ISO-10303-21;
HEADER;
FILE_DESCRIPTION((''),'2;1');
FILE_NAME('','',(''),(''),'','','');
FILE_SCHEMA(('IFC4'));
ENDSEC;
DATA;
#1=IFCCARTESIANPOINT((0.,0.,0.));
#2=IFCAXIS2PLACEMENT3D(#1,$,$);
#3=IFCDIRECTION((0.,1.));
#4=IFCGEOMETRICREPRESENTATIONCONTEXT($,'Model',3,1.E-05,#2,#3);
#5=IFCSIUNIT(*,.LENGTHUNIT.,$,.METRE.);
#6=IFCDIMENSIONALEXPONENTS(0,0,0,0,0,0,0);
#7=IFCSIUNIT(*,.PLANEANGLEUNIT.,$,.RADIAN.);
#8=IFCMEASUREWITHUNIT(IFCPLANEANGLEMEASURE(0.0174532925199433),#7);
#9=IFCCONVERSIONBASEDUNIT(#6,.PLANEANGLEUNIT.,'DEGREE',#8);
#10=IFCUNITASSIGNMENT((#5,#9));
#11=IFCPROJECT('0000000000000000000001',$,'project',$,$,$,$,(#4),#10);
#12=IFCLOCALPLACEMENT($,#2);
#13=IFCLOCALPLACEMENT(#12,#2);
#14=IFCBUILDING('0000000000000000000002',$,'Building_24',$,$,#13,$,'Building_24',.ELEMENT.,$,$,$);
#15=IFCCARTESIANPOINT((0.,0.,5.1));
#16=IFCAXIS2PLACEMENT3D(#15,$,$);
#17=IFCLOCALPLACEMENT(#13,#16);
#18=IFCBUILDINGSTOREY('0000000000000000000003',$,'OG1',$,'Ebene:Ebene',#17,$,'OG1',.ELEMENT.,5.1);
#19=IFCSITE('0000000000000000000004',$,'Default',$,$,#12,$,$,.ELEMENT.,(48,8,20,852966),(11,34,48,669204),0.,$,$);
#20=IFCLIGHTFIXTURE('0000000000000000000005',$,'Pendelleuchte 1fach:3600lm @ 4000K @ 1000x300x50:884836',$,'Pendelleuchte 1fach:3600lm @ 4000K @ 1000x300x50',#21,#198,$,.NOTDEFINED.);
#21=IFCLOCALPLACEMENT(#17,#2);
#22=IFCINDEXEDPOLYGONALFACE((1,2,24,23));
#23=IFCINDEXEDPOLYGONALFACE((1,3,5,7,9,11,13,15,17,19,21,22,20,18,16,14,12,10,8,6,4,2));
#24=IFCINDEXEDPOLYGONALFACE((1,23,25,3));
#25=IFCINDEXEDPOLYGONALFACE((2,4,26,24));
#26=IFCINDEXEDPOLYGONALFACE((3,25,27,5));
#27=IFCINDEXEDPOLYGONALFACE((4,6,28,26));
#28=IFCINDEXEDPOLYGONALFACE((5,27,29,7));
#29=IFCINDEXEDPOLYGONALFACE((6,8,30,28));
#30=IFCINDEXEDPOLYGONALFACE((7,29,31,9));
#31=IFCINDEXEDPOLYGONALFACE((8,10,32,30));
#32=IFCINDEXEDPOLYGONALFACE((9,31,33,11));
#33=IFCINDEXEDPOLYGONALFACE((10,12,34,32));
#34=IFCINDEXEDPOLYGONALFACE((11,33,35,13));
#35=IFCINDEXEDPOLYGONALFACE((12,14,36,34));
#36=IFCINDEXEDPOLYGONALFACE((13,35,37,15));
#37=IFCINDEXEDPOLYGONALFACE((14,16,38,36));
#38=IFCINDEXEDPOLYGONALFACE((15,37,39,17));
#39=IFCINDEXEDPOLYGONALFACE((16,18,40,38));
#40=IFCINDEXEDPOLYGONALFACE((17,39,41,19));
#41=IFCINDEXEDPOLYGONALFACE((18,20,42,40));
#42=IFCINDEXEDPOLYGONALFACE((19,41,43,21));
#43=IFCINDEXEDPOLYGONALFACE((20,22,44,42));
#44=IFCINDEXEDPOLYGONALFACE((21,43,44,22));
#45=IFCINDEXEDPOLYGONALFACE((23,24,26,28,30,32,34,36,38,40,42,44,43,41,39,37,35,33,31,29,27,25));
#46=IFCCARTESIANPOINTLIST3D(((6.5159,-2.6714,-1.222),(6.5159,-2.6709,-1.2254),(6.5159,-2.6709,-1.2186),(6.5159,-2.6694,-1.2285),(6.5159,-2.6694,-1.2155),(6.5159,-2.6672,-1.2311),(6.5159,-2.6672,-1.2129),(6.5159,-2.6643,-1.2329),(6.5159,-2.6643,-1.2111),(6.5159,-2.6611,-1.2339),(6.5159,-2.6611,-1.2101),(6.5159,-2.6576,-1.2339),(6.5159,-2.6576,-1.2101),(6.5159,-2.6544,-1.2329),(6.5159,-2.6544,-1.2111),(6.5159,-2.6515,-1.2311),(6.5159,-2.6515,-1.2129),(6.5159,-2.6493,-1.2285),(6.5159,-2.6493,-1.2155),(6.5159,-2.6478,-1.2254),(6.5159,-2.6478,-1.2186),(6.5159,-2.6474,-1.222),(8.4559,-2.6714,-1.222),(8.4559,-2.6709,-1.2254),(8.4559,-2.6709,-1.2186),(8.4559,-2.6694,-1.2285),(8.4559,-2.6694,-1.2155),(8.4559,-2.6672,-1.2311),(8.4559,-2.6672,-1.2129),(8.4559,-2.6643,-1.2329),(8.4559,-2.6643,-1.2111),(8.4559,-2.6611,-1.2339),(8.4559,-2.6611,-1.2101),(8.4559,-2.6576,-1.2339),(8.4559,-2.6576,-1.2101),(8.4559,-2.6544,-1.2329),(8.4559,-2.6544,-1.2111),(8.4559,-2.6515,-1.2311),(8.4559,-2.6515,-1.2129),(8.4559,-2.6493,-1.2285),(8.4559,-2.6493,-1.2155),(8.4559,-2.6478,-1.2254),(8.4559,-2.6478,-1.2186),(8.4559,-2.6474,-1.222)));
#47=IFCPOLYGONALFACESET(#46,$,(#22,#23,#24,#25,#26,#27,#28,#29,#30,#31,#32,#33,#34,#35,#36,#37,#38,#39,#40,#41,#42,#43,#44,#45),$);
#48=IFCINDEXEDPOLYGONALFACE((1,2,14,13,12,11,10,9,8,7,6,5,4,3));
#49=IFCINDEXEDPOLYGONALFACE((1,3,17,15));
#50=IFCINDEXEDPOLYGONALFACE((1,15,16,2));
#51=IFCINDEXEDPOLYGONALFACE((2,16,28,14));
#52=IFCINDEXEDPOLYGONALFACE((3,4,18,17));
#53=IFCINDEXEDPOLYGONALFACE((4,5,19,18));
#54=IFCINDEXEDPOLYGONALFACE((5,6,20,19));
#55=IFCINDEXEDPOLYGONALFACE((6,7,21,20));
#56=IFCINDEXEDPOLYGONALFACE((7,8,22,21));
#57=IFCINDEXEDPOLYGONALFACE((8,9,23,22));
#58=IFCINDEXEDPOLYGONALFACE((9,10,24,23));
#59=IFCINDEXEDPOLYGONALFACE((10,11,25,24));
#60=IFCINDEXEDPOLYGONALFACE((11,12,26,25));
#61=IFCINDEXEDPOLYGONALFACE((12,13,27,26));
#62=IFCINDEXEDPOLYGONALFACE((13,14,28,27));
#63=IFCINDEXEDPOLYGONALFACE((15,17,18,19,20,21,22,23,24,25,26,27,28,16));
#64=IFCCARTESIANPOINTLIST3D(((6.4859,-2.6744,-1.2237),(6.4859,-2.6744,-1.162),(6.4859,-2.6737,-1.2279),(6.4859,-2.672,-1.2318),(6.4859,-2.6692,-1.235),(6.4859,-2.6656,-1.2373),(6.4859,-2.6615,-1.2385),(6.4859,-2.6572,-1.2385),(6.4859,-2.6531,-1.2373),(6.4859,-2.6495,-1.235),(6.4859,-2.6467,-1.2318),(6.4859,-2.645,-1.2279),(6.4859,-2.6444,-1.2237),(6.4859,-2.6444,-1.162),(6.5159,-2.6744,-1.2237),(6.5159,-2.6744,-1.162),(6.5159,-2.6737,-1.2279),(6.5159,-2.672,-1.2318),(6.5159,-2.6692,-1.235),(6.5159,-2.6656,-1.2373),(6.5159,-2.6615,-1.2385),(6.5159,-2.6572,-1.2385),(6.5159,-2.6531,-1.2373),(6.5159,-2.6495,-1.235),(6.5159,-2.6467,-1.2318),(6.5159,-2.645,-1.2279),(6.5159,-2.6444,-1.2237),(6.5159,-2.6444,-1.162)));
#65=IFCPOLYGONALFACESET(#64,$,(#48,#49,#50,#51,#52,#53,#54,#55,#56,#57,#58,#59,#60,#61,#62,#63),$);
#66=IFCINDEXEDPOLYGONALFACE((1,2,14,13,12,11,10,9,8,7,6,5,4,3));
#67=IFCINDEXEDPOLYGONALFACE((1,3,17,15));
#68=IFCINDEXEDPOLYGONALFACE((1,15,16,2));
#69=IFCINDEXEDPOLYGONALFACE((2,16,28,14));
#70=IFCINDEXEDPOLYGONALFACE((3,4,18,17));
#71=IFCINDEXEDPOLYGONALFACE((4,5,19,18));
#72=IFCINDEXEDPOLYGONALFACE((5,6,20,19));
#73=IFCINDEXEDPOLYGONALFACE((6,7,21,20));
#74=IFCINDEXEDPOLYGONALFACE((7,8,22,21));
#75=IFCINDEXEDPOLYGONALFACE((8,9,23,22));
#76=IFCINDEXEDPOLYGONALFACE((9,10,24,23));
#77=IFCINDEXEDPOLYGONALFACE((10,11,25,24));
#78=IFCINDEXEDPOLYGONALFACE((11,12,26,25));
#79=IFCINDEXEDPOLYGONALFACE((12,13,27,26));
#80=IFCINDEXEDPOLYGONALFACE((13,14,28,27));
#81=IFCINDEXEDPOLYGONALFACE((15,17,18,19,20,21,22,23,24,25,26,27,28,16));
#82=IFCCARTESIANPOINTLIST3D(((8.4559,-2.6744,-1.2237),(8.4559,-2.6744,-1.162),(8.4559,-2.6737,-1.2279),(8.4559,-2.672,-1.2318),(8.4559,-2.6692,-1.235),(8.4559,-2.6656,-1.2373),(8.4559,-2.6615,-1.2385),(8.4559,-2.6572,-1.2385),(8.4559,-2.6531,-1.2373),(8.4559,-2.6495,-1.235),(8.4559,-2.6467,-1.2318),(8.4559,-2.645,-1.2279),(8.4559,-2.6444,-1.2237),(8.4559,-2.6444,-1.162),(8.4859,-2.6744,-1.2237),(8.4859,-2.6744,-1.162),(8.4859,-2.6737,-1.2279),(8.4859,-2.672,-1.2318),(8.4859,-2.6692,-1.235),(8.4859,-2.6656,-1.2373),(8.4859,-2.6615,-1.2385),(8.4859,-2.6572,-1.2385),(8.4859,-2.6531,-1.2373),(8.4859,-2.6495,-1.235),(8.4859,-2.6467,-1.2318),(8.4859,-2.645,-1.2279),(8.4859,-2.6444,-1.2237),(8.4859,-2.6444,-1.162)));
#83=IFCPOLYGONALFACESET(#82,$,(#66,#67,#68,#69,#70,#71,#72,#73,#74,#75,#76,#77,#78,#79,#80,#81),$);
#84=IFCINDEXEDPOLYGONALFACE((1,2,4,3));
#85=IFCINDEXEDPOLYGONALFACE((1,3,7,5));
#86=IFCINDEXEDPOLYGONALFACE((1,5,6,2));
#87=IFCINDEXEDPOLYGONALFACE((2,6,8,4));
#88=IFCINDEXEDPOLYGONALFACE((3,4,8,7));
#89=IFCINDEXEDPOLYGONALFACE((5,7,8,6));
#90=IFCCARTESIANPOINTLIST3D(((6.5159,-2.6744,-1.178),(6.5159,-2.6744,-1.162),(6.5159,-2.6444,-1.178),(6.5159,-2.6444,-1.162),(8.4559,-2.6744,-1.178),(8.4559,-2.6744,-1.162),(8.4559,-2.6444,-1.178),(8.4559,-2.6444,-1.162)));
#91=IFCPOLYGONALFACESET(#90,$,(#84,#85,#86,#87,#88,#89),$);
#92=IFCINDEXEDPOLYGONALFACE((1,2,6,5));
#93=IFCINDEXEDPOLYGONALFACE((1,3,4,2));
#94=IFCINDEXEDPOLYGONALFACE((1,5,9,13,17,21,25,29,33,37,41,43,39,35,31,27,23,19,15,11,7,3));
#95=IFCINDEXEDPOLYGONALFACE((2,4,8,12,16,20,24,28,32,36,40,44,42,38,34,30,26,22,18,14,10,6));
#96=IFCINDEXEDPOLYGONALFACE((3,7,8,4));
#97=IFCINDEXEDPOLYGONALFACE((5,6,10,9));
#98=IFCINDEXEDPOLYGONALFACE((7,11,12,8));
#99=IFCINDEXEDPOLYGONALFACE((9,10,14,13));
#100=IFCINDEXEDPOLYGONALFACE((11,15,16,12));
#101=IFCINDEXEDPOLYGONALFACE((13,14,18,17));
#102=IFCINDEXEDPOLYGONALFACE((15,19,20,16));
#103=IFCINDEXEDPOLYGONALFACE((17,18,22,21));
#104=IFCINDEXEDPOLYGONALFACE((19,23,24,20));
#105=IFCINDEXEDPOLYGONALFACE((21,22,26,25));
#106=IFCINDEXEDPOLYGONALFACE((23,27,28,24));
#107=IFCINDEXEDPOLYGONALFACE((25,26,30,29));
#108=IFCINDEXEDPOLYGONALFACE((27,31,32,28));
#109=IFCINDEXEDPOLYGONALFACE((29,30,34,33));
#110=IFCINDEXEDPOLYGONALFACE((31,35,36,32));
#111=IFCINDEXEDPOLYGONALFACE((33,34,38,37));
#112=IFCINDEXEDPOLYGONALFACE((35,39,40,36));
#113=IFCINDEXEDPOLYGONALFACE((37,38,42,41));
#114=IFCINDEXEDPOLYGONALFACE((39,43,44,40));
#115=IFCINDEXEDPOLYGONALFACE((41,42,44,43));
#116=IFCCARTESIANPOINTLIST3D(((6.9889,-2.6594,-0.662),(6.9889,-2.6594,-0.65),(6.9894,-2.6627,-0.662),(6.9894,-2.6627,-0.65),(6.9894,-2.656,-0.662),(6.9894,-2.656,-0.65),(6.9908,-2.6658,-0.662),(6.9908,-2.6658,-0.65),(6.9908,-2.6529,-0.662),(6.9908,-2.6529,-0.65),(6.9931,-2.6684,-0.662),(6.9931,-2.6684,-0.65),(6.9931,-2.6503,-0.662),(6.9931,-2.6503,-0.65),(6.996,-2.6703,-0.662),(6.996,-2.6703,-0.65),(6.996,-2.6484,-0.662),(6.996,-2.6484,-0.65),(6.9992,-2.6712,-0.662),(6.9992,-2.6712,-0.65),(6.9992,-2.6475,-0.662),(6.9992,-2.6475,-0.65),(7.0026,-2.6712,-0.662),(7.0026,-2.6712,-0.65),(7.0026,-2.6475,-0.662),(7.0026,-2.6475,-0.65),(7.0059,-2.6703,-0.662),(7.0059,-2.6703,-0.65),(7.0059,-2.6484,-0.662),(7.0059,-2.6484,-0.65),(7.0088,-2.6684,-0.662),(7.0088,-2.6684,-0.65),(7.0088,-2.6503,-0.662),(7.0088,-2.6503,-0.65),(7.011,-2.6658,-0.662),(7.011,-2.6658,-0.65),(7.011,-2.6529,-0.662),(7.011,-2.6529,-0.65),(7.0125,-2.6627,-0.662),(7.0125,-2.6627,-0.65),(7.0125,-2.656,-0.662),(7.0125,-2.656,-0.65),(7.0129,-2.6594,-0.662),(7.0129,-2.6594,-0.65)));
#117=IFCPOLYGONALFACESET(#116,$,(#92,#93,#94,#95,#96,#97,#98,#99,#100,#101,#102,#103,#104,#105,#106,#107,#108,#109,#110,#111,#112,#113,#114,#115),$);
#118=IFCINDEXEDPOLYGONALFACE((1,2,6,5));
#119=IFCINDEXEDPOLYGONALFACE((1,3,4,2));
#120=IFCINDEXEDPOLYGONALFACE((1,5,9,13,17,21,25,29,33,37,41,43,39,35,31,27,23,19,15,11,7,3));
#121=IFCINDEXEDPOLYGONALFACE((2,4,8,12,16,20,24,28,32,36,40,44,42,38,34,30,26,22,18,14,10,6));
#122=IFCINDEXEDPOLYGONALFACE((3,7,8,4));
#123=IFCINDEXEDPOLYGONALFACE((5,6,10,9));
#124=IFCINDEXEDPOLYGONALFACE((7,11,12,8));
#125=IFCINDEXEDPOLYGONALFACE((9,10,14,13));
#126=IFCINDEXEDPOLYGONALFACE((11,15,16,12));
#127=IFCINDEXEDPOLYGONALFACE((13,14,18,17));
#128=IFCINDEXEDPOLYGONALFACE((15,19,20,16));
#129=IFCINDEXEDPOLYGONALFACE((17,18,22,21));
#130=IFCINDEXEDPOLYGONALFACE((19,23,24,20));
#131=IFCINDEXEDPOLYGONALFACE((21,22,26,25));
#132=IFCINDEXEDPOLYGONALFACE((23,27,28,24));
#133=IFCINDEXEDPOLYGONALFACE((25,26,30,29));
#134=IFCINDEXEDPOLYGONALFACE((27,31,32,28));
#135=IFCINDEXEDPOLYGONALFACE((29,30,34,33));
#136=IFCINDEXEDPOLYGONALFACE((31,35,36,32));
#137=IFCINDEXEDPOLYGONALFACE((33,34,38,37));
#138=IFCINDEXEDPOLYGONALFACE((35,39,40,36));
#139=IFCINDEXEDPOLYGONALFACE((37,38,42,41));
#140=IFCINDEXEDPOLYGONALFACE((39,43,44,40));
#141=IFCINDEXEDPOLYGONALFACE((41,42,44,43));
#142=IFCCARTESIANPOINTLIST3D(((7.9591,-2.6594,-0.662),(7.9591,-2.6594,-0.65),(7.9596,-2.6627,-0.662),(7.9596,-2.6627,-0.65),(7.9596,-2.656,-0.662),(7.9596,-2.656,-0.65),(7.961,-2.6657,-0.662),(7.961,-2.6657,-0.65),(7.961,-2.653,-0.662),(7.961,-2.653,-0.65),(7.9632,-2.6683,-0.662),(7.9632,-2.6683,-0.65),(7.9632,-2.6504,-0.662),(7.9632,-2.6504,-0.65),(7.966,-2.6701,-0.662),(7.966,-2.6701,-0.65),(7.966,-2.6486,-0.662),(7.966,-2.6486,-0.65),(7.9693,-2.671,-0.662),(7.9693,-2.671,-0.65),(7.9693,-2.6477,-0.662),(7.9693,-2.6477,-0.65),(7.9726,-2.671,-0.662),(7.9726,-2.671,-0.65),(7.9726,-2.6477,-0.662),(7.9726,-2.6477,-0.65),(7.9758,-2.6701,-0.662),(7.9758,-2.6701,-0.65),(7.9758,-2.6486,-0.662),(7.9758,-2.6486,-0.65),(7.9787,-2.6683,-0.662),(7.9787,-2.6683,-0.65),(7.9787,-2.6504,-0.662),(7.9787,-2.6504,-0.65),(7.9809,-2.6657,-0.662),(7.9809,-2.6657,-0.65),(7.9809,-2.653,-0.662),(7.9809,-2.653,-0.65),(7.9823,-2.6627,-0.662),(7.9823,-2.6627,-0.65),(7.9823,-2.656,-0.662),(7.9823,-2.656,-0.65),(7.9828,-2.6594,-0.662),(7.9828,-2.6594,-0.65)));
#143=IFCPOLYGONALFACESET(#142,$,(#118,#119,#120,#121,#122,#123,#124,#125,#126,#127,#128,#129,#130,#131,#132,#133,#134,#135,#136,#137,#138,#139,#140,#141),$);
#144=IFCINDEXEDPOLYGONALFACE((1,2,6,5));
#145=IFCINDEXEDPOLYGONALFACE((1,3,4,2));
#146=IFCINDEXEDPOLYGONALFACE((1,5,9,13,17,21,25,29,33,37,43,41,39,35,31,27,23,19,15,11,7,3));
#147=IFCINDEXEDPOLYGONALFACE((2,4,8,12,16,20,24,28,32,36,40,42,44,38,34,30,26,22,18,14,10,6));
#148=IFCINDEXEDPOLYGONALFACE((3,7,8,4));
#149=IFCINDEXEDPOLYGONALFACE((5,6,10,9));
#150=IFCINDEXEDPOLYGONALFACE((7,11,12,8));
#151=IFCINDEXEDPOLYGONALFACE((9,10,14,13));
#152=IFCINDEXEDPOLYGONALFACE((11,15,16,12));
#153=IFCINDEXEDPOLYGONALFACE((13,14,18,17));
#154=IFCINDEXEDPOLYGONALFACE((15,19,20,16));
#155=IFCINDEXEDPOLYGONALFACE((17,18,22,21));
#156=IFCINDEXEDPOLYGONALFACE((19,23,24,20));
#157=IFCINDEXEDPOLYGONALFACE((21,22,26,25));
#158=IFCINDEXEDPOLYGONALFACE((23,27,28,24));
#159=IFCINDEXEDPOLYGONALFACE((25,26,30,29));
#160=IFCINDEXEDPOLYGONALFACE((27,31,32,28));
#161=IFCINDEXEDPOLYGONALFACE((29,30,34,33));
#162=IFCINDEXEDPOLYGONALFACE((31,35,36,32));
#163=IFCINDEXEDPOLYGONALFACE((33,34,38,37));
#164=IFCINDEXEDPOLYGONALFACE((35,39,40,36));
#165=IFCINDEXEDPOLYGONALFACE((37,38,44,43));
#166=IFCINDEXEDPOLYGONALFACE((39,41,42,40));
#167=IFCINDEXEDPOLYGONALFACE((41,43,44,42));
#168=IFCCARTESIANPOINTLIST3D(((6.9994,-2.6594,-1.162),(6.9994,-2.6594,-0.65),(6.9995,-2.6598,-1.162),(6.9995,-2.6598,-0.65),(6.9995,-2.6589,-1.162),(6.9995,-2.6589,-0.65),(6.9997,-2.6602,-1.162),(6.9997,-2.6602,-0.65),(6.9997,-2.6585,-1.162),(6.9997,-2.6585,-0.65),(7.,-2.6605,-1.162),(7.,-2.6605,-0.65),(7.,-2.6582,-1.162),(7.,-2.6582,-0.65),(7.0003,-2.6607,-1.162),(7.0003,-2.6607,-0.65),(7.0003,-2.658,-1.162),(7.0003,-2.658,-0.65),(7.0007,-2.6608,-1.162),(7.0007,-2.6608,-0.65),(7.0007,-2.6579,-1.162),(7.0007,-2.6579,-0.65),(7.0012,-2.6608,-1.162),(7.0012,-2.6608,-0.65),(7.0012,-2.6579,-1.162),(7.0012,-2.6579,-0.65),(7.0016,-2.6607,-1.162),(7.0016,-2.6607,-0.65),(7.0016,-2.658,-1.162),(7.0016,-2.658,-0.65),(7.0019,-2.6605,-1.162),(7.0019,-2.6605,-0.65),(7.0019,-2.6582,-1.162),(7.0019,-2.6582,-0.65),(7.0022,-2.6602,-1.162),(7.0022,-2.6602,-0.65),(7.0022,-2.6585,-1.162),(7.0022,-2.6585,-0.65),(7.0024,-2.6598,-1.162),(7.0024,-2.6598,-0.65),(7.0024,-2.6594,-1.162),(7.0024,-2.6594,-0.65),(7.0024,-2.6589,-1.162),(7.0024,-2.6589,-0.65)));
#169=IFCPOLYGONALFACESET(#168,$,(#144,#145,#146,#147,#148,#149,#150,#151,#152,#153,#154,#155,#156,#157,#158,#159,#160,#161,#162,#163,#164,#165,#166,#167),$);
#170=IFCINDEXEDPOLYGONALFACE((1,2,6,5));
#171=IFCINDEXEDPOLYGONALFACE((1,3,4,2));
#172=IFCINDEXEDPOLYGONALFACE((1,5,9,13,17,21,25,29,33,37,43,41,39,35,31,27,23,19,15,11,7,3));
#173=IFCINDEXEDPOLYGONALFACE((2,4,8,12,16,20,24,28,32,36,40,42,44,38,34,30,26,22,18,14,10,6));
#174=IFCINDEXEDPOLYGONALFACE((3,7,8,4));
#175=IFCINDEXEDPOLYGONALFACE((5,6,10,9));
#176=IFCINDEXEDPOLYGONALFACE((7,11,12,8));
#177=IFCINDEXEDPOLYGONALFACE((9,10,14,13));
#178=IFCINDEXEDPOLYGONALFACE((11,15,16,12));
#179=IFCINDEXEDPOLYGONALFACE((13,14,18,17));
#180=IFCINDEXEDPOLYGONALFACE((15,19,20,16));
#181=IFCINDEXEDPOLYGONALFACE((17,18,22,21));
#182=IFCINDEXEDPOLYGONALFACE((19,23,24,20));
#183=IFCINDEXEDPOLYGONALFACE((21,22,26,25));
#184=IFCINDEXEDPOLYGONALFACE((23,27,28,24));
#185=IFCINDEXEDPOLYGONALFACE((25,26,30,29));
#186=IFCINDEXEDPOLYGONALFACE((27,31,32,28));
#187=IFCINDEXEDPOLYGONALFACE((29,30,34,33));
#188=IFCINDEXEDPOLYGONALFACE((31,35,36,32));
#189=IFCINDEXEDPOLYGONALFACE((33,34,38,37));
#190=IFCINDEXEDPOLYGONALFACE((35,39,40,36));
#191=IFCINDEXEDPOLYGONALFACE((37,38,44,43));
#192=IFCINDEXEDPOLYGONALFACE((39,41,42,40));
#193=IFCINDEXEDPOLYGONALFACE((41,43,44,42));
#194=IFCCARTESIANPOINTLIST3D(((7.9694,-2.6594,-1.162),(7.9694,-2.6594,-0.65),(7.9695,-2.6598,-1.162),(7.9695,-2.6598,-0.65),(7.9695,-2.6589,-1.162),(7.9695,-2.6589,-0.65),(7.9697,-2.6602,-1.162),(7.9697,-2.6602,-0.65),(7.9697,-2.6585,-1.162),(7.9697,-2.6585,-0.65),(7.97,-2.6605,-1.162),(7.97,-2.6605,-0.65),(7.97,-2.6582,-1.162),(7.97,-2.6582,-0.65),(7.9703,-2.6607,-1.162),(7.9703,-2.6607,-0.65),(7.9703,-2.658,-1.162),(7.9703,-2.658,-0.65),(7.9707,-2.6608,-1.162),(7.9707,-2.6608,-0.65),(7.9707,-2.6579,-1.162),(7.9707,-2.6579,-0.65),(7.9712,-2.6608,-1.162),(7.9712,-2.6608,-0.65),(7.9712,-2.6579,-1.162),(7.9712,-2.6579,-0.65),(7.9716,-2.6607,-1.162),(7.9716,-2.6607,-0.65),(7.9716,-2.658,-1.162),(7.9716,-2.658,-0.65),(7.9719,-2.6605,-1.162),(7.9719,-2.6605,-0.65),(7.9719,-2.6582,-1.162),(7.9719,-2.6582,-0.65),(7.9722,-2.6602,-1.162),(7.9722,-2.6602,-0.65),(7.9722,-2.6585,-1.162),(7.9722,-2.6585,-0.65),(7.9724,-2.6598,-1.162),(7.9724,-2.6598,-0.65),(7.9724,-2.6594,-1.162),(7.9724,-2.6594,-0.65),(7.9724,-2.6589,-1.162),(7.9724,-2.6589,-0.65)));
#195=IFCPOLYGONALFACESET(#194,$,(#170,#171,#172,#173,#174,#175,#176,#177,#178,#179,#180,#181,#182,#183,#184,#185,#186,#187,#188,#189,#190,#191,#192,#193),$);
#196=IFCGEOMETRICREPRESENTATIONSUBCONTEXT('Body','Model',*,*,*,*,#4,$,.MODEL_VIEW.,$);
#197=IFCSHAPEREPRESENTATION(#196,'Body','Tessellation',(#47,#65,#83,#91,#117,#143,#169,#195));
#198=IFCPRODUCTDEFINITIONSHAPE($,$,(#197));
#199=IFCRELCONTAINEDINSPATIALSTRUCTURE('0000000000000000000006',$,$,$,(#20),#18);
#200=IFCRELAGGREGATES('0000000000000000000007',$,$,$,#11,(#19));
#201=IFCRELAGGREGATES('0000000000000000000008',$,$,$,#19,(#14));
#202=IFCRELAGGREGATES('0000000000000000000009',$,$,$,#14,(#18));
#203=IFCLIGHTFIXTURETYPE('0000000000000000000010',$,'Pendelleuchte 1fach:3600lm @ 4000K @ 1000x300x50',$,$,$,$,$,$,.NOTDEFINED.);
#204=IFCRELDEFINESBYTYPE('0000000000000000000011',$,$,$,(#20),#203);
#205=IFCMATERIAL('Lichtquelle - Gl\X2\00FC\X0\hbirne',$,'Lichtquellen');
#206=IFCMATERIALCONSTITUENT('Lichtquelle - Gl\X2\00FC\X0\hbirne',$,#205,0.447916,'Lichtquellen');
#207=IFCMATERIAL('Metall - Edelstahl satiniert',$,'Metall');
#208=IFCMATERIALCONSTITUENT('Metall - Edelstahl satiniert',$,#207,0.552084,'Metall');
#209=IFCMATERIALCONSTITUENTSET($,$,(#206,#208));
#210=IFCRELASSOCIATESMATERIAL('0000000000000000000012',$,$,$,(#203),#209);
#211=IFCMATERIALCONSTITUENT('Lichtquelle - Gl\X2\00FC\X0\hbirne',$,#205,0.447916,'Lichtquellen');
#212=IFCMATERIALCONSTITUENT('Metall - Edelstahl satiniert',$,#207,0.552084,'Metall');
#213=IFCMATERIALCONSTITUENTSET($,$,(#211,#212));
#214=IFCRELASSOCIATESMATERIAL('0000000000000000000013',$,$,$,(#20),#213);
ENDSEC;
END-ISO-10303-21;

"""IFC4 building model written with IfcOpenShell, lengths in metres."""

from ifc_helpers import new_model, entity, si_unit, converted_unit, direction, frame, origin, place, context, subcontext, project, spatial, line, arc, indexed_curve, outline, extrude, source, transform, mapped, material, constituent, constituent_set, type_object, type_shapes, element, save


model = new_model("IFC4")

# Units and contexts
model_context = context("Model", 3, precision=1e-05, world=origin(), true_north=direction((0.0, 1.0)))
body_context = subcontext(model_context, "Body", "Model", "MODEL_VIEW")
ifc_project = project(units=[si_unit("LENGTHUNIT", "METRE"), converted_unit("PLANEANGLEUNIT", "DEGREE", entity("IfcPlaneAngleMeasure", 0.0174532925199433), si_unit("PLANEANGLEUNIT", "RADIAN"), dimensions=[0, 0, 0, 0, 0, 0, 0])], contexts=[model_context])

# Site, building, storey
site_placement = place(None, origin())
site = spatial("IfcSite", under=ifc_project, at=site_placement, Name="Default", CompositionType="ELEMENT", RefLatitude=(48, 8, 20, 852966), RefLongitude=(11, 34, 48, 669204), RefElevation=0.0)
building_placement = place(site_placement, origin())
building = spatial("IfcBuilding", under=site, at=building_placement, Name="Building_24", LongName="Building_24", CompositionType="ELEMENT")
storey_placement = place(building_placement, frame((0.0, 0.0, 5.1)))
storey = spatial("IfcBuildingStorey", under=building, at=storey_placement, Name="OG1", ObjectType="Ebene:Ebene", LongName="OG1", CompositionType="ELEMENT", Elevation=5.1)

# Light fixture
ifc_material_1 = material(Name="Lichtquelle - Glühbirne", Category="Lichtquellen")
ifc_material_2 = material(Name="Metall - Edelstahl satiniert", Category="Metall")
ifc_constituent_1 = constituent(ifc_material_1, Name="Lichtquelle - Glühbirne", Category="Lichtquellen", fraction=0.447916)
ifc_constituent_2 = constituent(ifc_material_2, Name="Metall - Edelstahl satiniert", Category="Metall", fraction=0.552084)
ifc_constituent_set_1 = constituent_set(constituents=[ifc_constituent_1, ifc_constituent_2])
ifc_constituent_3 = constituent(ifc_material_1, Name="Lichtquelle - Glühbirne", Category="Lichtquellen", fraction=0.447916)
ifc_constituent_4 = constituent(ifc_material_2, Name="Metall - Edelstahl satiniert", Category="Metall", fraction=0.552084)
ifc_constituent_set_2 = constituent_set(constituents=[ifc_constituent_3, ifc_constituent_4])
light_fixture_type_1 = type_object("IfcLightFixtureType", Name="Pendelleuchte 1fach:3600lm @ 4000K @ 1000x300x50", PredefinedType="NOTDEFINED", material=ifc_constituent_set_2)
shared_shape_1 = source(origin(), body_context, "Body", "SweptSolid", [
    extrude(outline(indexed_curve([(-0.012, 0.0), (0.0, -0.012), (0.012, 0.0), (0.0, 0.012)], segments=[arc(1, 2, 3), arc(3, 4, 1)], self_intersect=False)), frame((-0.97, 0.0, -0.572), z_axis=(1.0, 0.0, 0.0), x_axis=(0.0, -1.0, 0.0)), (0.0, 0.0, 1.0), 1.94),
    extrude(outline(indexed_curve([(0.015, 0.0308), (0.0, 0.0458), (-0.015, 0.0308), (-0.015, -0.0308), (0.015, -0.0308)], segments=[arc(1, 2, 3), line(3, 4, 5, 1)], self_intersect=False)), frame((0.97, 0.0, -0.5428), z_axis=(1.0, 0.0, 0.0), x_axis=(0.0, -1.0, 0.0)), (0.0, 0.0, 1.0), 0.03),
    extrude(outline(indexed_curve([(0.015, 0.0308), (0.0, 0.0458), (-0.015, 0.0308), (-0.015, -0.0308), (0.015, -0.0308)], segments=[arc(1, 2, 3), line(3, 4, 5, 1)], self_intersect=False)), frame((-1.0, 0.0, -0.5428), z_axis=(1.0, 0.0, 0.0), x_axis=(0.0, -1.0, 0.0)), (0.0, 0.0, 1.0), 0.03),
    extrude(outline(indexed_curve([(-0.015, -0.97), (0.015, -0.97), (0.015, 0.97), (-0.015, 0.97), (-0.015, -0.97)], self_intersect=False)), frame((0.0, 0.0, -0.528), z_axis=(0.0, 0.0, 1.0), x_axis=(0.0, 1.0, 0.0)), (0.0, 0.0, 1.0), 0.016),
    extrude(outline(indexed_curve([(-0.012, 0.0), (0.0, -0.012), (0.012, 0.0), (0.0, 0.012)], segments=[arc(1, 2, 3), arc(3, 4, 1)], self_intersect=False)), frame((0.485, 0.0, -0.012)), (0.0, 0.0, 1.0), 0.012),
    extrude(outline(indexed_curve([(-0.0118, 0.0), (0.0, -0.0118), (0.0118, 0.0), (0.0, 0.0118)], segments=[arc(1, 2, 3), arc(3, 4, 1)], self_intersect=False)), frame((-0.485, 0.0, -0.012)), (0.0, 0.0, 1.0), 0.012),
    extrude(outline(indexed_curve([(-0.0015, 0.0), (0.0, -0.0015), (0.0015, 0.0), (0.0, 0.0015)], segments=[arc(1, 2, 3), arc(3, 4, 1)], self_intersect=False)), frame((0.485, 0.0, -0.512)), (0.0, 0.0, 1.0), 0.512),
    extrude(outline(indexed_curve([(-0.0015, 0.0), (0.0, -0.0015), (0.0015, 0.0), (0.0, 0.0015)], segments=[arc(1, 2, 3), arc(3, 4, 1)], self_intersect=False)), frame((-0.485, 0.0, -0.512)), (0.0, 0.0, 1.0), 0.512),
])
type_shapes(light_fixture_type_1, [shared_shape_1])
light_fixture_1_placement = place(storey_placement, frame((7.4859, -2.6594, -0.65), z_axis=(0.0, 0.0, 1.0), x_axis=(-1.0, 0.0, 0.0)))
element("IfcLightFixture", 1, at=light_fixture_1_placement, inside=storey, type_object=light_fixture_type_1, material=ifc_constituent_set_1, Name="Pendelleuchte 1fach:3600lm @ 4000K @ 1000x300x50:884836", ObjectType="Pendelleuchte 1fach:3600lm @ 4000K @ 1000x300x50", PredefinedType="NOTDEFINED", context=body_context, shape_type="MappedRepresentation", body=[
    mapped(shared_shape_1, transform((0.0, 0.0, 0.0), scale=1.0)),
])

save(model, "model.ifc")
